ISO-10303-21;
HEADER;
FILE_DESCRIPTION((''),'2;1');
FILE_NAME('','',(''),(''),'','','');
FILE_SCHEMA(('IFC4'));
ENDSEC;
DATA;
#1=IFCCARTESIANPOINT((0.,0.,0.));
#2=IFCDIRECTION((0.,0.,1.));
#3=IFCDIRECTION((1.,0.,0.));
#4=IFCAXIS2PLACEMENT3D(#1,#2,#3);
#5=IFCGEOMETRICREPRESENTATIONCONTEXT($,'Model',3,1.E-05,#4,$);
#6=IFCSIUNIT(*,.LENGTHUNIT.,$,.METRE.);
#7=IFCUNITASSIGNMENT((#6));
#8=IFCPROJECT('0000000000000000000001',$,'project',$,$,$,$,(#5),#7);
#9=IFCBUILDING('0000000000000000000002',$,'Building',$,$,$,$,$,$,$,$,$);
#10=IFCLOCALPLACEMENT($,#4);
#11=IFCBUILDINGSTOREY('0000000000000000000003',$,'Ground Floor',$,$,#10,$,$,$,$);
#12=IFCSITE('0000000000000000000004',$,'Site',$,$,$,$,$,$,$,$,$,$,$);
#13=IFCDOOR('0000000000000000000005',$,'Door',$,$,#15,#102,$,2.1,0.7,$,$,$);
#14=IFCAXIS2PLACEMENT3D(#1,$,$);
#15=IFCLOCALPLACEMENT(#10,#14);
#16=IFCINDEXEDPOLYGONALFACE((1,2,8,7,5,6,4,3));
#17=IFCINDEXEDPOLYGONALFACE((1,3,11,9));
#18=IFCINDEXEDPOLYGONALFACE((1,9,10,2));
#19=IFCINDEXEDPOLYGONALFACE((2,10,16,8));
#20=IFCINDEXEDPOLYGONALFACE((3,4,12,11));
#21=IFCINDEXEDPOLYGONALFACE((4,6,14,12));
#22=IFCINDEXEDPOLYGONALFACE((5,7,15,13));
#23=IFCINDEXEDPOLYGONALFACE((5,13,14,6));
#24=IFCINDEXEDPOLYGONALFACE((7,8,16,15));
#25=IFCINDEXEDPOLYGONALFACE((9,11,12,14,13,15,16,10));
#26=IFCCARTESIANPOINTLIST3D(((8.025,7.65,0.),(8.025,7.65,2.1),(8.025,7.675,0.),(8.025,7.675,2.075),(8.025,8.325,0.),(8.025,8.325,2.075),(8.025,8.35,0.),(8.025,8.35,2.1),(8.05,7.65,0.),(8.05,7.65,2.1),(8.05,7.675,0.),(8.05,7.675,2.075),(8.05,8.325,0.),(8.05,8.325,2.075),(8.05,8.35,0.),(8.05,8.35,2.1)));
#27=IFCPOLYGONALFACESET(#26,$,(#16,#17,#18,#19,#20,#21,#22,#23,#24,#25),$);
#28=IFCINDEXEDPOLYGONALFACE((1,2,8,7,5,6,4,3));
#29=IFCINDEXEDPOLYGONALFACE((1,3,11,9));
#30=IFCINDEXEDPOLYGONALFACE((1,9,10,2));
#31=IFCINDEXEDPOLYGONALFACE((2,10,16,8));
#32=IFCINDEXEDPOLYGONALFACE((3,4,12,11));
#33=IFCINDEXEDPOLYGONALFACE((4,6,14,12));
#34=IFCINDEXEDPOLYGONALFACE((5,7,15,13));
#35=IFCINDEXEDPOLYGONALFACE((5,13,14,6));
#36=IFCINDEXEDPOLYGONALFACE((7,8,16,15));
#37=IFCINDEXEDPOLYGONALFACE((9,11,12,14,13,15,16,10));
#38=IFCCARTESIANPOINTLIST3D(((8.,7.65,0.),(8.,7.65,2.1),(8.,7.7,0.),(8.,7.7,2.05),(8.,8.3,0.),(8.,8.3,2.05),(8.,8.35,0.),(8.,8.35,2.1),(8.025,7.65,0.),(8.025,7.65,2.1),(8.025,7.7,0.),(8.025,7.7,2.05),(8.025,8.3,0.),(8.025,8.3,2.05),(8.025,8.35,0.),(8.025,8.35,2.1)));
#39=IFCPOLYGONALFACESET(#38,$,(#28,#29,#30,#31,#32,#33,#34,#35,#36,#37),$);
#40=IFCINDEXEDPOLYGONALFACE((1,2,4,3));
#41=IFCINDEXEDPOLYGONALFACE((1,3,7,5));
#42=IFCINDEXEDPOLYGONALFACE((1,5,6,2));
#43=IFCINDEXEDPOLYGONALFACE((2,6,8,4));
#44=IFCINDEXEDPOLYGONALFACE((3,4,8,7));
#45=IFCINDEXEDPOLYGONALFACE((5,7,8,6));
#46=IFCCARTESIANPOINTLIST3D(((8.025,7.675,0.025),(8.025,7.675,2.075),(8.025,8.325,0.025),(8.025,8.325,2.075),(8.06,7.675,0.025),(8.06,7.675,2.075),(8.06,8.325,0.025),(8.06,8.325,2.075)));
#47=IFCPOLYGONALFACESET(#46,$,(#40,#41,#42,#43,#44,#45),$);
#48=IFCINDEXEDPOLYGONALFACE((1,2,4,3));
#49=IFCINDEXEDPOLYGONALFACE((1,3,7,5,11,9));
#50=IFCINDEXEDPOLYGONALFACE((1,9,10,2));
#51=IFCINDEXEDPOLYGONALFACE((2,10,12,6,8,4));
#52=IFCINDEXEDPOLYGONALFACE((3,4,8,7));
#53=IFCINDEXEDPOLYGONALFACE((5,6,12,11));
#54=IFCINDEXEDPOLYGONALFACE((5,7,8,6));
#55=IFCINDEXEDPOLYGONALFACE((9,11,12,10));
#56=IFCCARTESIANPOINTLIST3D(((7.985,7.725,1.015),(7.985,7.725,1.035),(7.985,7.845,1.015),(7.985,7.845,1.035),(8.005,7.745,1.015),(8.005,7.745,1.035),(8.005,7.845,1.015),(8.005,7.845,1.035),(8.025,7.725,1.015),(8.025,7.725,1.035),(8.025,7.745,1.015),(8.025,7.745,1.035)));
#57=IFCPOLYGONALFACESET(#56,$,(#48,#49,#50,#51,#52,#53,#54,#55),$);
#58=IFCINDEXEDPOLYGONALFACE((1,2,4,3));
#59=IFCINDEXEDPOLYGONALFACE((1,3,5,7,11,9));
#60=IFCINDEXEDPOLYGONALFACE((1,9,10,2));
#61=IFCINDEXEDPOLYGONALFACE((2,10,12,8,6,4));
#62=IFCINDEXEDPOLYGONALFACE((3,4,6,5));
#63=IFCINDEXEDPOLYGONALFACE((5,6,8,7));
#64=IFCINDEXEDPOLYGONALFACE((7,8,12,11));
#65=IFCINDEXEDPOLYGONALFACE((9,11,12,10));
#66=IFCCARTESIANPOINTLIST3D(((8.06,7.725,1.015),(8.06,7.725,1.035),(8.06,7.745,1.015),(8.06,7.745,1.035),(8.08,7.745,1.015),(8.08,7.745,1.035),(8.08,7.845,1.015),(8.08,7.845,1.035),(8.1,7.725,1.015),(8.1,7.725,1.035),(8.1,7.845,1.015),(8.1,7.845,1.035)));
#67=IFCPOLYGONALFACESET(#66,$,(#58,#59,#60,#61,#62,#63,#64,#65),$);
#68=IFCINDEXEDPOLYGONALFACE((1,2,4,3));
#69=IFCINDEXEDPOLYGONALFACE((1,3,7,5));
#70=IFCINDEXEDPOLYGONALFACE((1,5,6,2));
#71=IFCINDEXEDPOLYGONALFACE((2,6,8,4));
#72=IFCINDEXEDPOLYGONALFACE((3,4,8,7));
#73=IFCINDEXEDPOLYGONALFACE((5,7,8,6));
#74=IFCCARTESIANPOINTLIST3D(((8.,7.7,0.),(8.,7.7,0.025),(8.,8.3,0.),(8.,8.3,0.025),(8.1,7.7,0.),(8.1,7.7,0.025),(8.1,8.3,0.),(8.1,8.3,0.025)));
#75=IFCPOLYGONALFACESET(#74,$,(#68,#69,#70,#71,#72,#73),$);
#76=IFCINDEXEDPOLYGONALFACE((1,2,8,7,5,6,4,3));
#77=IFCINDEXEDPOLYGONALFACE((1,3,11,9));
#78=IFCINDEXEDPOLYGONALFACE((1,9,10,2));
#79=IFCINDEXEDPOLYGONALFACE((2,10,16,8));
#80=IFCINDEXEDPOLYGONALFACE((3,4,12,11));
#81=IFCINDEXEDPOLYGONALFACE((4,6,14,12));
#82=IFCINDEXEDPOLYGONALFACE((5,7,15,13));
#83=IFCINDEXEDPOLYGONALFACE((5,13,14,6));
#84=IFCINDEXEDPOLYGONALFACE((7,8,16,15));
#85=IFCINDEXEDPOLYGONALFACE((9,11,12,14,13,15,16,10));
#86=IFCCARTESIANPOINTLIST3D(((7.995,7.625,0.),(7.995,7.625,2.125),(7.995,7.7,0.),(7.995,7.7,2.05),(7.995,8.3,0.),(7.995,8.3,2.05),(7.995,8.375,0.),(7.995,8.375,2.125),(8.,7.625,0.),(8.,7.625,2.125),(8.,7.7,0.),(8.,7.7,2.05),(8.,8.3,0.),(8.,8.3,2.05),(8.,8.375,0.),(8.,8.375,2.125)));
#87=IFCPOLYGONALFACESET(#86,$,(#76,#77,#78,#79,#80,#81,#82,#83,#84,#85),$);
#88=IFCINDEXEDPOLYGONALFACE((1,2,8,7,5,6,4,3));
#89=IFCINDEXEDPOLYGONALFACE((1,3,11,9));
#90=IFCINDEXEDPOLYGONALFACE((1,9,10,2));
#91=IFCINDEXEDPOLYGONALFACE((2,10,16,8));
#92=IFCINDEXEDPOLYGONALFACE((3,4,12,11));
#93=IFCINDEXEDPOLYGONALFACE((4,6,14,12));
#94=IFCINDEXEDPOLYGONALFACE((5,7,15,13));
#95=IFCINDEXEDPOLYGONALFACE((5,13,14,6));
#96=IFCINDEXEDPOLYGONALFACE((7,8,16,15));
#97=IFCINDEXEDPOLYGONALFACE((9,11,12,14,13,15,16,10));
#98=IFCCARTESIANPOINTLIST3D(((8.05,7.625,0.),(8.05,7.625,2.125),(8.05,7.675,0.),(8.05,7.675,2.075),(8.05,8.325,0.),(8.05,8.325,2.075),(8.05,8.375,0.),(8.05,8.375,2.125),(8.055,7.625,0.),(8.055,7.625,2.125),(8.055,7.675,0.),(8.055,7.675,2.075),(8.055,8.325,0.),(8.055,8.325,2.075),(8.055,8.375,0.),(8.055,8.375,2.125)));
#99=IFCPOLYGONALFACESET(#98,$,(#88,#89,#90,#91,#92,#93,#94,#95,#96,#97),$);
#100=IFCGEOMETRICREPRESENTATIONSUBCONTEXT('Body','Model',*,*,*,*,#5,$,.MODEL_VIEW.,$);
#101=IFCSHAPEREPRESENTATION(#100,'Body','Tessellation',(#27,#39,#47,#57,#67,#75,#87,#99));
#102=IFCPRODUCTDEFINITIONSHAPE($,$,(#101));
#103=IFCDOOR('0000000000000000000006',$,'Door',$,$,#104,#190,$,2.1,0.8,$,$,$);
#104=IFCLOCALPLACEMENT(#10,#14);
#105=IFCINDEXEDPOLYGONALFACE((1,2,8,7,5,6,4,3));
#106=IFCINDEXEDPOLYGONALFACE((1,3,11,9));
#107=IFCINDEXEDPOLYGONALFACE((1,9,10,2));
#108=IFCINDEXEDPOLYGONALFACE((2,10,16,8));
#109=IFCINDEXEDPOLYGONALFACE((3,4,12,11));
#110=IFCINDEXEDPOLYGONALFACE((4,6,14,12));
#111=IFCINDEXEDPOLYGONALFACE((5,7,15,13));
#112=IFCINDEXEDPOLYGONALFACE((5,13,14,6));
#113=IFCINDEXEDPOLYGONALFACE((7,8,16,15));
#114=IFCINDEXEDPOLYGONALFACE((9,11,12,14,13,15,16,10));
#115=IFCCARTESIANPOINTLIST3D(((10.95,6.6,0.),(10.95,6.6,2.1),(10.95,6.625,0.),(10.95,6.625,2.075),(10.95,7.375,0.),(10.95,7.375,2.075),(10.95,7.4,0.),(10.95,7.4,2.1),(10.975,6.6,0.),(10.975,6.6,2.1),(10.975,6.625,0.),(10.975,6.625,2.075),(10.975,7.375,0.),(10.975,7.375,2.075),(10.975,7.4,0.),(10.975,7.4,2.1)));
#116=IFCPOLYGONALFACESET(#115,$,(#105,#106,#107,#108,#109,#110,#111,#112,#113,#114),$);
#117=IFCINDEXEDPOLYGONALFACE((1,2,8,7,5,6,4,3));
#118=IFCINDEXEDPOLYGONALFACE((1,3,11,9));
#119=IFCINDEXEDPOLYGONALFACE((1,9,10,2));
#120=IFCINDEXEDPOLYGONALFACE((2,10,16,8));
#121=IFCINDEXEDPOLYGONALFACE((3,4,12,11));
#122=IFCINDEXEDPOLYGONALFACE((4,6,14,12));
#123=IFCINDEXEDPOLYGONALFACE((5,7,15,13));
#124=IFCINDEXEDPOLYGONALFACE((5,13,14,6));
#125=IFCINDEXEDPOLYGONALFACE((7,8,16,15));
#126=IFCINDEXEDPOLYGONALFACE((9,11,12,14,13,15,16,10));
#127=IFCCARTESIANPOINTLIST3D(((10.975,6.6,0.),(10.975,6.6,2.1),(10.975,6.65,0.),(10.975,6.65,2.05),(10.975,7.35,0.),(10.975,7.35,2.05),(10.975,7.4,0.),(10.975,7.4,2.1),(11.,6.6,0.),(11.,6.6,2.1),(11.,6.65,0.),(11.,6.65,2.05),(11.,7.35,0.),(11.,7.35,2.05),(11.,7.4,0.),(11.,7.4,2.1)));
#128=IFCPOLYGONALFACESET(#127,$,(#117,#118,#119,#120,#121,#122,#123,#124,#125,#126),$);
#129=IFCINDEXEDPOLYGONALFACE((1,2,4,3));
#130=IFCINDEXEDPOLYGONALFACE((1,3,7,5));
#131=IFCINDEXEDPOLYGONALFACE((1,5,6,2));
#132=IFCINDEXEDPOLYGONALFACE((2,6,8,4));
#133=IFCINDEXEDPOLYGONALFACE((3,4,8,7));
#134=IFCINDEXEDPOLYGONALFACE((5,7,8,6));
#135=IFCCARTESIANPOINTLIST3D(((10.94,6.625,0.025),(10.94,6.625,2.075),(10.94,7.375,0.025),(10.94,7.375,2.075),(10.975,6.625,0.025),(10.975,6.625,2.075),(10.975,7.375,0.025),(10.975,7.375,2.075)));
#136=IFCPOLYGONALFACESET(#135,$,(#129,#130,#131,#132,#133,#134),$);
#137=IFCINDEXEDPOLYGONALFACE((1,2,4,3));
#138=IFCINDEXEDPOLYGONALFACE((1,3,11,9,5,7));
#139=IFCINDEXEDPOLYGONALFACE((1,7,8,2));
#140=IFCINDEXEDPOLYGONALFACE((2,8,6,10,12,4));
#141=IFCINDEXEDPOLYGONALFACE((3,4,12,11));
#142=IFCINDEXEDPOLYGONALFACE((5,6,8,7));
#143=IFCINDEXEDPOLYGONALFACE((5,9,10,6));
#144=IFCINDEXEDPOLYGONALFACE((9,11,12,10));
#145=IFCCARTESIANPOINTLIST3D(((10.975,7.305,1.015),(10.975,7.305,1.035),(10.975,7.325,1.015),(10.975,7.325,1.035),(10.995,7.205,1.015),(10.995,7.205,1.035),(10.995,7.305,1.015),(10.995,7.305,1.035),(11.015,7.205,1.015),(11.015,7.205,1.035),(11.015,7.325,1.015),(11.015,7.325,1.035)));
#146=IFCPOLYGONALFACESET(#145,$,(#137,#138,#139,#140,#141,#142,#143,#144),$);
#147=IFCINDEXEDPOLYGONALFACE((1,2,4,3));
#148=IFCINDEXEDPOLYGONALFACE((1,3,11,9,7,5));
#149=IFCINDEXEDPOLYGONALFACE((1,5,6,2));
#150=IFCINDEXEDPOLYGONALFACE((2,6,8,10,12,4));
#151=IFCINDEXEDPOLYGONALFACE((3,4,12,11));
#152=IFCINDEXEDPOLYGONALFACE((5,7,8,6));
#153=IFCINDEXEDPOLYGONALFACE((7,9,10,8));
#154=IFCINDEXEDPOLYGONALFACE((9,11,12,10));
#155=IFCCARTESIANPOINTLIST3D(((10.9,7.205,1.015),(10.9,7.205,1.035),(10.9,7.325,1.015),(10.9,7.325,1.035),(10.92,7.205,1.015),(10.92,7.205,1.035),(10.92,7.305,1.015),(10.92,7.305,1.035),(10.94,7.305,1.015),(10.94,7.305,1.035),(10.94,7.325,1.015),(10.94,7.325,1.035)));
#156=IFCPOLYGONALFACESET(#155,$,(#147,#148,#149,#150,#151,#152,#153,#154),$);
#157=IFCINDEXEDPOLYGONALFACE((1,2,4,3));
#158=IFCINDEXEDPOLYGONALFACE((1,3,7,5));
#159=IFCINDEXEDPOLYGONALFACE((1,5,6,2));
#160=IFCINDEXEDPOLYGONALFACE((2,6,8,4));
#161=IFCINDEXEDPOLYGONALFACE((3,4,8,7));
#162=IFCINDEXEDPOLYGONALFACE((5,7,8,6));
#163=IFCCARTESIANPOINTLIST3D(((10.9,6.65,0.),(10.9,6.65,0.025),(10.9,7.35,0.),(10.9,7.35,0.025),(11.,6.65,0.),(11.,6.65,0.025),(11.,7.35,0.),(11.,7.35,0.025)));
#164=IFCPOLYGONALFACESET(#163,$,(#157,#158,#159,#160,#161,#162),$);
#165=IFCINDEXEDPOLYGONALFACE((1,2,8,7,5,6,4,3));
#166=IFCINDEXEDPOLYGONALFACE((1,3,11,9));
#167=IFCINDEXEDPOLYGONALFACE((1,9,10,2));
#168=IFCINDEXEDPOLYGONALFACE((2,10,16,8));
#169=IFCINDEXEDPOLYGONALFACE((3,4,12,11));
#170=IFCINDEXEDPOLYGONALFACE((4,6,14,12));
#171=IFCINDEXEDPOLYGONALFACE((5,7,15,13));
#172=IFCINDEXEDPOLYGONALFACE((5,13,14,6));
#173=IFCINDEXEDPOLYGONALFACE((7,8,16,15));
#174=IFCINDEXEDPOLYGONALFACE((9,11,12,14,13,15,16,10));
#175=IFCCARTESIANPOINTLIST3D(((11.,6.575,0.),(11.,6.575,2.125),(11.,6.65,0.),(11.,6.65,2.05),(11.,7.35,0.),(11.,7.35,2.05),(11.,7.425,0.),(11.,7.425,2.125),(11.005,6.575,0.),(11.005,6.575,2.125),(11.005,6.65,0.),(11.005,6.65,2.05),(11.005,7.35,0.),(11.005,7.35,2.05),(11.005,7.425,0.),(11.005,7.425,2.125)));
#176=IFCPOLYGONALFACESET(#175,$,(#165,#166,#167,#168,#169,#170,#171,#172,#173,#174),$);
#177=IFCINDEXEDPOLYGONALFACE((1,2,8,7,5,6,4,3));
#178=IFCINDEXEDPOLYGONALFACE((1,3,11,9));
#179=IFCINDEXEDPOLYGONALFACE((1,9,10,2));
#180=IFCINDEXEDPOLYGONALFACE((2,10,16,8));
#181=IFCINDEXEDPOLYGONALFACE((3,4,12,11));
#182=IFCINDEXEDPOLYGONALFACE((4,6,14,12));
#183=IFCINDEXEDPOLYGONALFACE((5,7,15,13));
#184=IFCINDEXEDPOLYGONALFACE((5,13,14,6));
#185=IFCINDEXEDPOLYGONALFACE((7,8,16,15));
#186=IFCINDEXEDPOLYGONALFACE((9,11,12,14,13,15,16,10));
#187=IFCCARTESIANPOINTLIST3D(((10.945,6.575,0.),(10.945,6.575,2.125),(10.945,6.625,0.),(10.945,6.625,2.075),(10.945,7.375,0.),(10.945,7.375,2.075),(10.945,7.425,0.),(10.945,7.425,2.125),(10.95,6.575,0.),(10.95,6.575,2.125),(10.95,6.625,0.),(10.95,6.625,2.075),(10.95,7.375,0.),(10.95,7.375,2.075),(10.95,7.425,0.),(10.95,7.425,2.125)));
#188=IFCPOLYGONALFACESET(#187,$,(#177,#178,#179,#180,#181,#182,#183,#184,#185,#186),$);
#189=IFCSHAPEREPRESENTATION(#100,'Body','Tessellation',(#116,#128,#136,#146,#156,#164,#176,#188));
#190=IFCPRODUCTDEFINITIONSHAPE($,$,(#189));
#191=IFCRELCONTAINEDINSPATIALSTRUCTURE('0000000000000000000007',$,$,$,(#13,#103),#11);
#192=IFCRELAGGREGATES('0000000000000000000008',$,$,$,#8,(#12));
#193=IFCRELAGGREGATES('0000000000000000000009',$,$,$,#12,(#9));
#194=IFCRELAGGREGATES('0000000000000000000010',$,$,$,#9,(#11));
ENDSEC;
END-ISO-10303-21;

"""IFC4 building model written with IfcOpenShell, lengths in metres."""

from ifc_helpers import new_model, si_unit, frame, origin_with_axes, place, context, subcontext, project, spatial, line, indexed_curve, outline, extrude, element, save


model = new_model("IFC4")

# Units and contexts
model_context = context("Model", 3, precision=1e-05, world=origin_with_axes())
body_context = subcontext(model_context, "Body", "Model", "MODEL_VIEW")
ifc_project = project(units=[si_unit("LENGTHUNIT", "METRE")], contexts=[model_context])

# Site, building, storey
site = spatial("IfcSite", under=ifc_project, Name="Site")
building = spatial("IfcBuilding", under=site, Name="Building")
storey_placement = place(None, origin_with_axes())
storey = spatial("IfcBuildingStorey", under=building, at=storey_placement, Name="Ground Floor")

# Doors
door_1_placement = place(storey_placement, frame((8.0, 8.35, 0.0), z_axis=(0.0, 0.0, 1.0), x_axis=(0.0, -1.0, 0.0)))
element("IfcDoor", 1, at=door_1_placement, inside=storey, Name="Door", OverallHeight=2.1, OverallWidth=0.7, context=body_context, shape_type="SweptSolid", body=[
    extrude(outline(indexed_curve([(0.0, 0.0), (0.0, 2.1), (0.7, 2.1), (0.7, 0.0), (0.675, 0.0), (0.675, 2.075), (0.025, 2.075), (0.025, 0.0)], segments=[line(1, 2, 3, 4, 5, 6, 7, 8, 1)])), frame((0.0, 0.025, 0.0), z_axis=(0.0, -1.0, 0.0), x_axis=(1.0, 0.0, 0.0)), (0.0, 0.0, -1.0), 0.025),
    extrude(outline(indexed_curve([(0.0, 0.0), (0.0, 2.1), (0.7, 2.1), (0.7, 0.0), (0.65, 0.0), (0.65, 2.05), (0.05, 2.05), (0.05, 0.0)], segments=[line(1, 2, 3, 4, 5, 6, 7, 8, 1)])), frame((0.0, 0.0, 0.0), z_axis=(0.0, -1.0, 0.0), x_axis=(1.0, 0.0, 0.0)), (0.0, 0.0, -1.0), 0.025),
    extrude(outline(indexed_curve([(0.0, 0.0), (0.65, 0.0), (0.65, 0.035), (0.0, 0.035)], segments=[line(1, 2, 3, 4, 1)])), frame((0.025, 0.025, 0.025), z_axis=(0.0, 0.0, 1.0), x_axis=(1.0, 0.0, 0.0)), (0.0, 0.0, 1.0), 2.05),
    extrude(outline(indexed_curve([(0.0, 0.0), (0.0, -0.04), (-0.12, -0.04), (-0.12, -0.02), (-0.02, -0.02), (-0.02, 0.0)], segments=[line(1, 2, 3, 4, 5, 6, 1)])), frame((0.625, 0.025, 1.015), z_axis=(0.0, 0.0, 1.0), x_axis=(1.0, 0.0, 0.0)), (0.0, 0.0, 1.0), 0.02),
    extrude(outline(indexed_curve([(0.0, 0.0), (0.0, 0.04), (-0.12, 0.04), (-0.12, 0.02), (-0.02, 0.02), (-0.02, 0.0)], segments=[line(1, 2, 3, 4, 5, 6, 1)])), frame((0.625, 0.06, 1.015), z_axis=(0.0, 0.0, 1.0), x_axis=(1.0, 0.0, 0.0)), (0.0, 0.0, 1.0), 0.02),
    extrude(outline(indexed_curve([(0.0, 0.0), (0.6, 0.0), (0.6, 0.1), (0.0, 0.1)], segments=[line(1, 2, 3, 4, 1)])), frame((0.05, 0.0, 0.0), z_axis=(0.0, 0.0, 1.0), x_axis=(1.0, 0.0, 0.0)), (0.0, 0.0, 1.0), 0.025),
    extrude(outline(indexed_curve([(0.0, 0.0), (0.0, 2.125), (0.75, 2.125), (0.75, 0.0), (0.675, 0.0), (0.675, 2.05), (0.075, 2.05), (0.075, 0.0)], segments=[line(1, 2, 3, 4, 5, 6, 7, 8, 1)])), frame((-0.025, -0.005, 0.0), z_axis=(0.0, -1.0, 0.0), x_axis=(1.0, 0.0, 0.0)), (0.0, 0.0, -1.0), 0.005),
    extrude(outline(indexed_curve([(0.0, 0.0), (0.0, 2.125), (0.75, 2.125), (0.75, 0.0), (0.7, 0.0), (0.7, 2.075), (0.05, 2.075), (0.05, 0.0)], segments=[line(1, 2, 3, 4, 5, 6, 7, 8, 1)])), frame((-0.025, 0.05, 0.0), z_axis=(0.0, -1.0, 0.0), x_axis=(1.0, 0.0, 0.0)), (0.0, 0.0, -1.0), 0.005),
])
door_2_placement = place(storey_placement, frame((11.0, 6.6, 0.0), z_axis=(0.0, 0.0, 1.0), x_axis=(0.0, 1.0, 0.0)))
element("IfcDoor", 2, at=door_2_placement, inside=storey, Name="Door", OverallHeight=2.1, OverallWidth=0.8, context=body_context, shape_type="SweptSolid", body=[
    extrude(outline(indexed_curve([(0.0, 0.0), (0.0, 2.1), (0.8, 2.1), (0.8, 0.0), (0.775, 0.0), (0.775, 2.075), (0.025, 2.075), (0.025, 0.0)], segments=[line(1, 2, 3, 4, 5, 6, 7, 8, 1)])), frame((0.0, 0.025, 0.0), z_axis=(0.0, -1.0, 0.0), x_axis=(1.0, 0.0, 0.0)), (0.0, 0.0, -1.0), 0.025),
    extrude(outline(indexed_curve([(0.0, 0.0), (0.0, 2.1), (0.8, 2.1), (0.8, 0.0), (0.75, 0.0), (0.75, 2.05), (0.05, 2.05), (0.05, 0.0)], segments=[line(1, 2, 3, 4, 5, 6, 7, 8, 1)])), frame((0.0, 0.0, 0.0), z_axis=(0.0, -1.0, 0.0), x_axis=(1.0, 0.0, 0.0)), (0.0, 0.0, -1.0), 0.025),
    extrude(outline(indexed_curve([(0.0, 0.0), (0.75, 0.0), (0.75, 0.035), (0.0, 0.035)], segments=[line(1, 2, 3, 4, 1)])), frame((0.025, 0.025, 0.025), z_axis=(0.0, 0.0, 1.0), x_axis=(1.0, 0.0, 0.0)), (0.0, 0.0, 1.0), 2.05),
    extrude(outline(indexed_curve([(0.0, 0.0), (0.0, -0.04), (-0.12, -0.04), (-0.12, -0.02), (-0.02, -0.02), (-0.02, 0.0)], segments=[line(1, 2, 3, 4, 5, 6, 1)])), frame((0.725, 0.025, 1.015), z_axis=(0.0, 0.0, 1.0), x_axis=(1.0, 0.0, 0.0)), (0.0, 0.0, 1.0), 0.02),
    extrude(outline(indexed_curve([(0.0, 0.0), (0.0, 0.04), (-0.12, 0.04), (-0.12, 0.02), (-0.02, 0.02), (-0.02, 0.0)], segments=[line(1, 2, 3, 4, 5, 6, 1)])), frame((0.725, 0.06, 1.015), z_axis=(0.0, 0.0, 1.0), x_axis=(1.0, 0.0, 0.0)), (0.0, 0.0, 1.0), 0.02),
    extrude(outline(indexed_curve([(0.0, 0.0), (0.7, 0.0), (0.7, 0.1), (0.0, 0.1)], segments=[line(1, 2, 3, 4, 1)])), frame((0.05, 0.0, 0.0), z_axis=(0.0, 0.0, 1.0), x_axis=(1.0, 0.0, 0.0)), (0.0, 0.0, 1.0), 0.025),
    extrude(outline(indexed_curve([(0.0, 0.0), (0.0, 2.125), (0.85, 2.125), (0.85, 0.0), (0.775, 0.0), (0.775, 2.05), (0.075, 2.05), (0.075, 0.0)], segments=[line(1, 2, 3, 4, 5, 6, 7, 8, 1)])), frame((-0.025, -0.005, 0.0), z_axis=(0.0, -1.0, 0.0), x_axis=(1.0, 0.0, 0.0)), (0.0, 0.0, -1.0), 0.005),
    extrude(outline(indexed_curve([(0.0, 0.0), (0.0, 2.125), (0.85, 2.125), (0.85, 0.0), (0.8, 0.0), (0.8, 2.075), (0.05, 2.075), (0.05, 0.0)], segments=[line(1, 2, 3, 4, 5, 6, 7, 8, 1)])), frame((-0.025, 0.05, 0.0), z_axis=(0.0, -1.0, 0.0), x_axis=(1.0, 0.0, 0.0)), (0.0, 0.0, -1.0), 0.005),
])

save(model, "model.ifc")
